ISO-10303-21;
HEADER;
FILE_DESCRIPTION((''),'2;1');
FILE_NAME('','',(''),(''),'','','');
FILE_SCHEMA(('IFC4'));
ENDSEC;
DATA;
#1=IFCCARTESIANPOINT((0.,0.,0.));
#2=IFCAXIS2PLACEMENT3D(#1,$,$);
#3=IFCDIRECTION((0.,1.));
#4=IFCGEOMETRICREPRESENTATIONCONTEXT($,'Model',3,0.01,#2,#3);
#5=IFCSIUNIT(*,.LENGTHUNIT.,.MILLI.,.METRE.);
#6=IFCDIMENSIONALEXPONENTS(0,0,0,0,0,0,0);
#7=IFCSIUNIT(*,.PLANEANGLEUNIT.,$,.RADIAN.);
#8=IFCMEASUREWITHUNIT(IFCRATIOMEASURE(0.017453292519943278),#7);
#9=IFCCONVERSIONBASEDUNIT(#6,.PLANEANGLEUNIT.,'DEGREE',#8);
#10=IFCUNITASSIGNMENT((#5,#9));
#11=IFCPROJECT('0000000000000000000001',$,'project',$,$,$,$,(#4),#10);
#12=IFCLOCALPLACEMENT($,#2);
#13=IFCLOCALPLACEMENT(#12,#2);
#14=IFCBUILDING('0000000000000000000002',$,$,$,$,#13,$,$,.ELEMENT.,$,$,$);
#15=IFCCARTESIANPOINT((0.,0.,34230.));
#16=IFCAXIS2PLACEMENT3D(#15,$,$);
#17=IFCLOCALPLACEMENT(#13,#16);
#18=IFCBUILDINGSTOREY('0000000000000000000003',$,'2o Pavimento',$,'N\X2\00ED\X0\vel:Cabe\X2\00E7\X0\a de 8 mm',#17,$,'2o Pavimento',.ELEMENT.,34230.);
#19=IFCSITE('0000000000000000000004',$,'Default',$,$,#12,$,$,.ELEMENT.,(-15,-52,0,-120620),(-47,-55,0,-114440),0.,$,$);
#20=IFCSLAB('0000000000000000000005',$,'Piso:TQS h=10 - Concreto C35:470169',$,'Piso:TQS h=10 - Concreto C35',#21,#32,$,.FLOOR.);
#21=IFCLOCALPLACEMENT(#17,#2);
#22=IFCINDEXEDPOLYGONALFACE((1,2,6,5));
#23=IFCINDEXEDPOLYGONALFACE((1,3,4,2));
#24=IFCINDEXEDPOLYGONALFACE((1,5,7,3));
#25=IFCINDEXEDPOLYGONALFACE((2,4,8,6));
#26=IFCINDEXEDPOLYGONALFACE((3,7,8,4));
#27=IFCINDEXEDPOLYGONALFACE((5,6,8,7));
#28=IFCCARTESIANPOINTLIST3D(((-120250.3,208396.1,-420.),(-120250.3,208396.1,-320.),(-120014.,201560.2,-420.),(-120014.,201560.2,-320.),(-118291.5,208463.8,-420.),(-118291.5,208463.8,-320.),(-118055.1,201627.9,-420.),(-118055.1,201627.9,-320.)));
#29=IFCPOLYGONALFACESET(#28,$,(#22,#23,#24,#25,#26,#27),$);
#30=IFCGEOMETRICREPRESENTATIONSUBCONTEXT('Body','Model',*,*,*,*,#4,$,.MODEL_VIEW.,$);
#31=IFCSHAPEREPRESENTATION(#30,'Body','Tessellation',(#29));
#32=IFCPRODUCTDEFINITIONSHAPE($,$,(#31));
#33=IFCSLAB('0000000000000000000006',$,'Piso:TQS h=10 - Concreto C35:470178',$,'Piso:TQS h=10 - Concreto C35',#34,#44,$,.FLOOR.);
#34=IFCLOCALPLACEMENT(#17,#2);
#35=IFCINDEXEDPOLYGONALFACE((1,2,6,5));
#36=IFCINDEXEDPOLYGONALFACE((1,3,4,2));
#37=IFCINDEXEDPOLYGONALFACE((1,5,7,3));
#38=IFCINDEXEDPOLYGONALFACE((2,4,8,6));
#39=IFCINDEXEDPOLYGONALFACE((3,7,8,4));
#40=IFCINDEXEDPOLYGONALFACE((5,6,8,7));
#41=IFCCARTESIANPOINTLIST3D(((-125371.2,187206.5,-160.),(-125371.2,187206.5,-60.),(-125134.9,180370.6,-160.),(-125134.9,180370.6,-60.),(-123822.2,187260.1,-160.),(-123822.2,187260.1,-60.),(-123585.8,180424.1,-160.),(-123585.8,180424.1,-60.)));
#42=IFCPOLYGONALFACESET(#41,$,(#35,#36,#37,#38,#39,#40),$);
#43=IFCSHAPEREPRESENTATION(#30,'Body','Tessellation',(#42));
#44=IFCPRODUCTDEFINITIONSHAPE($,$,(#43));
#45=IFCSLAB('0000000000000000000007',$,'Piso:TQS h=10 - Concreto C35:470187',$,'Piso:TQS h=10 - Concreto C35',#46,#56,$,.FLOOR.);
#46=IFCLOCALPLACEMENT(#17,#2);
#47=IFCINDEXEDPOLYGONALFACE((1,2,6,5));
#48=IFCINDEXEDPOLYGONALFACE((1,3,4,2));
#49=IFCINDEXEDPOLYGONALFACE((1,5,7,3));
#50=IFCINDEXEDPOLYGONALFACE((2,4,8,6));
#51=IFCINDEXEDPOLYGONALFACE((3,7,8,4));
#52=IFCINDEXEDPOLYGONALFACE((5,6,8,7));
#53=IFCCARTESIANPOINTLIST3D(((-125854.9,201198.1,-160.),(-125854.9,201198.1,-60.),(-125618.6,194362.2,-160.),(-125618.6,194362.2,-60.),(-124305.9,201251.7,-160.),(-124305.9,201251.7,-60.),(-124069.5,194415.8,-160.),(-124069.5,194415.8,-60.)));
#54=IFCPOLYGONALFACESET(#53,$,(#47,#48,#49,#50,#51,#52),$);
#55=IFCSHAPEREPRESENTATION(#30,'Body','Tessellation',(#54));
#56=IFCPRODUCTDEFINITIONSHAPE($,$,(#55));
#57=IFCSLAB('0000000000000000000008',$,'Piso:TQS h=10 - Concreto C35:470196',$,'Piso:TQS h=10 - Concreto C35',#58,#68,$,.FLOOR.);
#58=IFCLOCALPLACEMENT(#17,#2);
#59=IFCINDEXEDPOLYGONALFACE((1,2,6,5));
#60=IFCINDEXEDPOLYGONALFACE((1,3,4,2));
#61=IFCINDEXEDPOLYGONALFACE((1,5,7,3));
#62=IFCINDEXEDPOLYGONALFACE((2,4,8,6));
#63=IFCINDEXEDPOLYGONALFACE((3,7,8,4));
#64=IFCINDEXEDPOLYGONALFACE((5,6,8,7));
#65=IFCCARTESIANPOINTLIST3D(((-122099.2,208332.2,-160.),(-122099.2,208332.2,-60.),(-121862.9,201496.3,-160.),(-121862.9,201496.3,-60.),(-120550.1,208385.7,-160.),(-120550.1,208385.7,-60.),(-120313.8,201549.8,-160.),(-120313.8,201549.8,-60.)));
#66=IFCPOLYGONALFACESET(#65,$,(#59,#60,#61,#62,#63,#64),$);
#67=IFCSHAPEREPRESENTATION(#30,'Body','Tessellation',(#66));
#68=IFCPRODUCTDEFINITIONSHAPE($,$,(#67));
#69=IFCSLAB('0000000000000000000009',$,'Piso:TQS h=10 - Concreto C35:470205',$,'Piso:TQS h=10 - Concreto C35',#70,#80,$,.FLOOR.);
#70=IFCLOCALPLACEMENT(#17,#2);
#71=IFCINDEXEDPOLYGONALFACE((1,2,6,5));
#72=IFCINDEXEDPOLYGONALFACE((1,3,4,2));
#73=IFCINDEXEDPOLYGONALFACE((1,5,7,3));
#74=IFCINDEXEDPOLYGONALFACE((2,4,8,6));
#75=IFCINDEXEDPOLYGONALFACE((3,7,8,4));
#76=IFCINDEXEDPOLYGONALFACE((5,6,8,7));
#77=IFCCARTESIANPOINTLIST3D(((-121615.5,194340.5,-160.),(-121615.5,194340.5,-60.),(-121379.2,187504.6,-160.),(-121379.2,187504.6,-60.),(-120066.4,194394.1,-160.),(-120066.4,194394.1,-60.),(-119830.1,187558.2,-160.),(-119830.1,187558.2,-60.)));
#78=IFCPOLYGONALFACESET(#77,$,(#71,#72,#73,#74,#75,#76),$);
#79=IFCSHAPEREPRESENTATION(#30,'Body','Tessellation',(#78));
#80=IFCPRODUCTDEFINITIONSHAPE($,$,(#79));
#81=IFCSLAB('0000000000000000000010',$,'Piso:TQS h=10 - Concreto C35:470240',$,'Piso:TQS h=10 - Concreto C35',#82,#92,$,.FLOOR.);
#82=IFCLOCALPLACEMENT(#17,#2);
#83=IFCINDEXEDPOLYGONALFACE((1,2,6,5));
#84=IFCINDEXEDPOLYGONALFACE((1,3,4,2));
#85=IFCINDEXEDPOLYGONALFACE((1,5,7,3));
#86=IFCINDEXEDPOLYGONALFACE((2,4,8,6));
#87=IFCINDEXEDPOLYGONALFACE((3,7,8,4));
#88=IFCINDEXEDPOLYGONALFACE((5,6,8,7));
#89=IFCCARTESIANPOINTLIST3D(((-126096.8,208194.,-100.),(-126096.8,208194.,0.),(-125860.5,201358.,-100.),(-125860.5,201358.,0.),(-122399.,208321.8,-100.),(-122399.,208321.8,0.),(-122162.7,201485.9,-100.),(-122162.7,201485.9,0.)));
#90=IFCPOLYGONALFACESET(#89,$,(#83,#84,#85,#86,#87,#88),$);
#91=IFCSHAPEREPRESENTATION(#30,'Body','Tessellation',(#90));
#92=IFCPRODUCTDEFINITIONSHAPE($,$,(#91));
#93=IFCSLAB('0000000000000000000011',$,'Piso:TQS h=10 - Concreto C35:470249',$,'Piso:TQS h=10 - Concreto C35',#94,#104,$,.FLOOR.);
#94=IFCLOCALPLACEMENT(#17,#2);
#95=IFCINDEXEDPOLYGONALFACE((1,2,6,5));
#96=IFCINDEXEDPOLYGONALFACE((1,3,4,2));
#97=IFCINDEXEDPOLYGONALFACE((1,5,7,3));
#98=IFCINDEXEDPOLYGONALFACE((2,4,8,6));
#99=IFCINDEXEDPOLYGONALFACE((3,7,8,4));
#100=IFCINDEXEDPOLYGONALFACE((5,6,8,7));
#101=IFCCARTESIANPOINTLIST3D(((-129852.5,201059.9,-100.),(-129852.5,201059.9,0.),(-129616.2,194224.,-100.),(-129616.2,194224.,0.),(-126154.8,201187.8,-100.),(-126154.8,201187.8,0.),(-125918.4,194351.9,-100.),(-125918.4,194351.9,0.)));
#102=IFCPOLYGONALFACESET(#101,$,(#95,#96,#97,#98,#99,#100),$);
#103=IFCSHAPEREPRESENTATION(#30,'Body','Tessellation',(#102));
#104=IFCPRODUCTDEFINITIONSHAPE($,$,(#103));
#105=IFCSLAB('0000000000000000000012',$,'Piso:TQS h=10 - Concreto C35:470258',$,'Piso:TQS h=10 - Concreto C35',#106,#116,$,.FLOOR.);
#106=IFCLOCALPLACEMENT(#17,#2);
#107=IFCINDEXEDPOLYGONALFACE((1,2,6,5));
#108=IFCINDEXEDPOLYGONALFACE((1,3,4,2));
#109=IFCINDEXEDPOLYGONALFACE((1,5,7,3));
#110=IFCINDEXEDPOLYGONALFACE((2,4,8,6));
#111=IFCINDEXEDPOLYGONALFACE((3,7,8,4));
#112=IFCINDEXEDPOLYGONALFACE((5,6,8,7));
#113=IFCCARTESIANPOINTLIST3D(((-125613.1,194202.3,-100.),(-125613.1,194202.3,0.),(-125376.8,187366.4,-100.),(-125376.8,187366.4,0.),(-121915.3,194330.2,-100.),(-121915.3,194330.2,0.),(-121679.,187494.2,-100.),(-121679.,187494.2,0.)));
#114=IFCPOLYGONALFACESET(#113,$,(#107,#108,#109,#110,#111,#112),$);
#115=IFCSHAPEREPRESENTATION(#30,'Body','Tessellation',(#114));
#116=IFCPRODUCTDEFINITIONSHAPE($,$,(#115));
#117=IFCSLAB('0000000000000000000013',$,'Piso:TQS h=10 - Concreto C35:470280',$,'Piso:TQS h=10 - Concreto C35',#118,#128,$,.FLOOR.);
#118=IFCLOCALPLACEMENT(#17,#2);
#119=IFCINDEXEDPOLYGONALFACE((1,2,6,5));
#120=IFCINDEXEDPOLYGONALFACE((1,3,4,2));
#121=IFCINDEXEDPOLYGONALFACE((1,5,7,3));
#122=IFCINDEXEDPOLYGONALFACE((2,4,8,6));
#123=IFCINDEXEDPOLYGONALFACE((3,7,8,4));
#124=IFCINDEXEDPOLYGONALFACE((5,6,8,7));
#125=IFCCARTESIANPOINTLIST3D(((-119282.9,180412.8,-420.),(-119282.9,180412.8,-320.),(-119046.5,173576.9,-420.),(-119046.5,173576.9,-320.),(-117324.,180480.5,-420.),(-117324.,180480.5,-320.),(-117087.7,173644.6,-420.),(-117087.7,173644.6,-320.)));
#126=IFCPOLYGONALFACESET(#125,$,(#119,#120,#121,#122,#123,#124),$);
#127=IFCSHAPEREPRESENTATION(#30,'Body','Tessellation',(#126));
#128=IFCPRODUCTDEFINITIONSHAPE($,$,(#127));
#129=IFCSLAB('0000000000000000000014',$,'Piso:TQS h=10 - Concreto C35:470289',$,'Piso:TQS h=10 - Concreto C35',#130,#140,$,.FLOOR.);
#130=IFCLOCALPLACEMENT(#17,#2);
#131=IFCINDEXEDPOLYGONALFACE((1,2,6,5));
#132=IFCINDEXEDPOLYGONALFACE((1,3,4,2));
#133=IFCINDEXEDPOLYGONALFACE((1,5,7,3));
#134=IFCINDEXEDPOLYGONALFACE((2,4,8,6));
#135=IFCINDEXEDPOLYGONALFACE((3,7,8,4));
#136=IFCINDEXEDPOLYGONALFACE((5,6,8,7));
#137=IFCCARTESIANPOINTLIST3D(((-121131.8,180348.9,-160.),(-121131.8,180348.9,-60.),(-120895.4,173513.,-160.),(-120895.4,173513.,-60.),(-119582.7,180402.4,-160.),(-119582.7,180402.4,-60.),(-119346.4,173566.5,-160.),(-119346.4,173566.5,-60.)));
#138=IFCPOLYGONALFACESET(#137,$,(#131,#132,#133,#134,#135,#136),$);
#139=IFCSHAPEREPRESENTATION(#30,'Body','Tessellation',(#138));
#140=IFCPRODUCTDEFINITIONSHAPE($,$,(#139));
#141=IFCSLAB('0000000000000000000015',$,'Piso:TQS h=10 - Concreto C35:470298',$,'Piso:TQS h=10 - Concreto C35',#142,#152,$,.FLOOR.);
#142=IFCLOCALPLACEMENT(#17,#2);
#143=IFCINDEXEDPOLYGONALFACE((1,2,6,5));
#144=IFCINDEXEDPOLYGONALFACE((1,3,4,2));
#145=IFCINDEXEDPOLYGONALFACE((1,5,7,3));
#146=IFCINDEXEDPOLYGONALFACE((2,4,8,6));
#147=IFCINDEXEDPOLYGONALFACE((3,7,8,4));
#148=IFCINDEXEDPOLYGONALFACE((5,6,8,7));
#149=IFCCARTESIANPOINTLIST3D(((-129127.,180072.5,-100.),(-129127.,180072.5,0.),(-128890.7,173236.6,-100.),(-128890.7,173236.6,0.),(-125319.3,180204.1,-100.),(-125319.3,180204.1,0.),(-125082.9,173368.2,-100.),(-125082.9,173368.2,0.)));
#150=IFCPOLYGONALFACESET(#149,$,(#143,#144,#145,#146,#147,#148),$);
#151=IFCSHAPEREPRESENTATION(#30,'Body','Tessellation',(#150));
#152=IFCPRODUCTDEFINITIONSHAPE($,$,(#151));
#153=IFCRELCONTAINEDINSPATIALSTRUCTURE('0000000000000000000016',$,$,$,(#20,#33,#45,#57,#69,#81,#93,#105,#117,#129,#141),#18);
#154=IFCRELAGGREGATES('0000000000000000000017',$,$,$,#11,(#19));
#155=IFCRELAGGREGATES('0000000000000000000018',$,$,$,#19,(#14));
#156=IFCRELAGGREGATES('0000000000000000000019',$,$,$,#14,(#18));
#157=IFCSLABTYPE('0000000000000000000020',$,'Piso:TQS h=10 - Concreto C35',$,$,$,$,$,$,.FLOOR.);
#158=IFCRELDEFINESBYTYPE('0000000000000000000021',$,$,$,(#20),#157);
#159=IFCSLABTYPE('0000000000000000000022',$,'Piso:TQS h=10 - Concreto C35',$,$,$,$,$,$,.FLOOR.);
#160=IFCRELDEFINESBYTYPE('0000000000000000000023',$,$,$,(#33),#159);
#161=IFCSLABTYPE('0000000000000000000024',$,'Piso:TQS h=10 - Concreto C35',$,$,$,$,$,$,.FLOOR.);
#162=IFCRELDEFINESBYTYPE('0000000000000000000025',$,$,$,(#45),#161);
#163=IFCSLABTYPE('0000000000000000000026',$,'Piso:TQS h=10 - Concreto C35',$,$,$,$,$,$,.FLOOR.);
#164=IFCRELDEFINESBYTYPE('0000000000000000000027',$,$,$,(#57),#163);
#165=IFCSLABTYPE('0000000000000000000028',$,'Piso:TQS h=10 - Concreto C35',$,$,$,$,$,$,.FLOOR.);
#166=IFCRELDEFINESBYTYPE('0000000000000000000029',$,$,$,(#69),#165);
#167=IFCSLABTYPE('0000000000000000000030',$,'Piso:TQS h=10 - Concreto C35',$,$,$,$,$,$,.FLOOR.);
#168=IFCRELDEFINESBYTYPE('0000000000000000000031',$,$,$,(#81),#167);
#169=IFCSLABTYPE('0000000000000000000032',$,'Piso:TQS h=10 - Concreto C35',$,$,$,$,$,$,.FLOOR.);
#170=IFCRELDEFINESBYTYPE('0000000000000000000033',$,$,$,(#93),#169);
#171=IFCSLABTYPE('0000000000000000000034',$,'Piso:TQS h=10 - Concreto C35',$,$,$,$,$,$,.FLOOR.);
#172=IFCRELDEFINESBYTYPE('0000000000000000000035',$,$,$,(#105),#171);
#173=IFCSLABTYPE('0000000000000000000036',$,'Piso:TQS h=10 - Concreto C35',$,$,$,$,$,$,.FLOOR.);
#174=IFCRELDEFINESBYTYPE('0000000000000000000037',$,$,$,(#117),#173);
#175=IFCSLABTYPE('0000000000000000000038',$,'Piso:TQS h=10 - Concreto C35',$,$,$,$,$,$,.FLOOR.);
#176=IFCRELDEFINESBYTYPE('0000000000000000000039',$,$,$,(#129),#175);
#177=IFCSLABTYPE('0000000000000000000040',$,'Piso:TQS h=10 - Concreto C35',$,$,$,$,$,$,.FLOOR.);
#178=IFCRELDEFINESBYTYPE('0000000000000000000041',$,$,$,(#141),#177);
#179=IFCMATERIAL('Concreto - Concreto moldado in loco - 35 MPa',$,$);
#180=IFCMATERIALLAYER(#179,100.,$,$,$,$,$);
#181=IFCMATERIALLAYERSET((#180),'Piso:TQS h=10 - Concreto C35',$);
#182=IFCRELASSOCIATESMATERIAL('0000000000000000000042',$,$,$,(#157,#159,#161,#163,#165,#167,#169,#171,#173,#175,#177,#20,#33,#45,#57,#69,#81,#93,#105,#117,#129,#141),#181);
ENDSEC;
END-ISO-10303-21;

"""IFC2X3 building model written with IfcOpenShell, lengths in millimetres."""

from ifc_helpers import new_model, entity, si_unit, converted_unit, direction, frame, frame_2d, origin, origin_2d_with_axis, place, context, subcontext, project, spatial, rectangle, extrude, material, layer, layer_set, layer_usage, type_object, element, save


model = new_model("IFC2X3")

# Units and contexts
model_context = context("Model", 3, precision=0.01, world=origin(), true_north=direction((0.0, 1.0)))
body_context = subcontext(model_context, "Body", "Model", "MODEL_VIEW")
ifc_project = project(units=[si_unit("LENGTHUNIT", "METRE", prefix="MILLI"), converted_unit("PLANEANGLEUNIT", "DEGREE", entity("IfcRatioMeasure", 0.017453292519943278), si_unit("PLANEANGLEUNIT", "RADIAN"), dimensions=[0, 0, 0, 0, 0, 0, 0])], contexts=[model_context])

# Site, building, storey
site_placement = place(None, origin())
site = spatial("IfcSite", under=ifc_project, at=site_placement, Name="Default", CompositionType="ELEMENT", RefLatitude=(-15, -52, 0, -120620), RefLongitude=(-47, -55, 0, -114440), RefElevation=0.0)
building_placement = place(site_placement, origin())
building = spatial("IfcBuilding", under=site, at=building_placement, CompositionType="ELEMENT")
storey_placement = place(building_placement, frame((0.0, 0.0, 34230.0)))
storey = spatial("IfcBuildingStorey", under=building, at=storey_placement, Name="2o Pavimento", ObjectType="Nível:Cabeça de 8 mm", LongName="2o Pavimento", CompositionType="ELEMENT", Elevation=34230.0)

# Shared definitions
ifc_material = material(Name="Concreto - Concreto moldado in loco - 35 MPa")

# Slabs
ifc_layer = layer(ifc_material, 100.0)
ifc_layer_set = layer_set([ifc_layer], Name="Piso:TQS h=10 - Concreto C35")
ifc_layer_usage_1 = layer_usage(ifc_layer_set, "AXIS3", "POSITIVE", 0.0)
slab_type_1 = type_object("IfcSlabType", Name="Piso:TQS h=10 - Concreto C35", PredefinedType="FLOOR", material=ifc_layer_set)
slab_1_placement = place(storey_placement, origin())
element("IfcSlab", 1, at=slab_1_placement, inside=storey, type_object=slab_type_1, material=ifc_layer_usage_1, Name="Piso:TQS h=10 - Concreto C35:470169", ObjectType="Piso:TQS h=10 - Concreto C35", PredefinedType="FLOOR", context=body_context, shape_type="SweptSolid", body=[
    extrude(rectangle(XDim=6840.0, YDim=1960.0, at=frame_2d((0.0, 0.0), x_axis=(1.0, 0.0))), frame((-119152.7, 205012.0, -320.0), z_axis=(0.0, 0.0, -1.0), x_axis=(0.034551, -0.999403, 0.0)), (0.0, 0.0, 1.0), 100.0),
])
ifc_layer_usage_2 = layer_usage(ifc_layer_set, "AXIS3", "POSITIVE", 0.0)
slab_type_2 = type_object("IfcSlabType", Name="Piso:TQS h=10 - Concreto C35", PredefinedType="FLOOR", material=ifc_layer_set)
slab_2_placement = place(storey_placement, origin())
element("IfcSlab", 2, at=slab_2_placement, inside=storey, type_object=slab_type_2, material=ifc_layer_usage_2, Name="Piso:TQS h=10 - Concreto C35:470178", ObjectType="Piso:TQS h=10 - Concreto C35", PredefinedType="FLOOR", context=body_context, shape_type="SweptSolid", body=[
    extrude(rectangle(XDim=6840.0, YDim=1550.0, at=frame_2d((0.0, 0.0), x_axis=(1.0, 0.0))), frame((-124478.5, 183815.3, -60.0), z_axis=(0.0, 0.0, -1.0), x_axis=(0.034551, -0.999403, 0.0)), (0.0, 0.0, 1.0), 100.0),
])
ifc_layer_usage_3 = layer_usage(ifc_layer_set, "AXIS3", "POSITIVE", 0.0)
slab_type_3 = type_object("IfcSlabType", Name="Piso:TQS h=10 - Concreto C35", PredefinedType="FLOOR", material=ifc_layer_set)
slab_3_placement = place(storey_placement, origin())
element("IfcSlab", 3, at=slab_3_placement, inside=storey, type_object=slab_type_3, material=ifc_layer_usage_3, Name="Piso:TQS h=10 - Concreto C35:470187", ObjectType="Piso:TQS h=10 - Concreto C35", PredefinedType="FLOOR", context=body_context, shape_type="SweptSolid", body=[
    extrude(rectangle(XDim=6840.0, YDim=1550.0, at=frame_2d((0.0, 0.0), x_axis=(1.0, 0.0))), frame((-124962.2, 197807.0, -60.0), z_axis=(0.0, 0.0, -1.0), x_axis=(0.034551, -0.999403, 0.0)), (0.0, 0.0, 1.0), 100.0),
])
ifc_layer_usage_4 = layer_usage(ifc_layer_set, "AXIS3", "POSITIVE", 0.0)
slab_type_4 = type_object("IfcSlabType", Name="Piso:TQS h=10 - Concreto C35", PredefinedType="FLOOR", material=ifc_layer_set)
slab_4_placement = place(storey_placement, origin())
element("IfcSlab", 4, at=slab_4_placement, inside=storey, type_object=slab_type_4, material=ifc_layer_usage_4, Name="Piso:TQS h=10 - Concreto C35:470196", ObjectType="Piso:TQS h=10 - Concreto C35", PredefinedType="FLOOR", context=body_context, shape_type="SweptSolid", body=[
    extrude(rectangle(XDim=6840.0, YDim=1550.0, at=frame_2d((0.0, 0.0), x_axis=(1.0, 0.0))), frame((-121206.5, 204941.0, -60.0), z_axis=(0.0, 0.0, -1.0), x_axis=(0.034551, -0.999403, 0.0)), (0.0, 0.0, 1.0), 100.0),
])
ifc_layer_usage_5 = layer_usage(ifc_layer_set, "AXIS3", "POSITIVE", 0.0)
slab_type_5 = type_object("IfcSlabType", Name="Piso:TQS h=10 - Concreto C35", PredefinedType="FLOOR", material=ifc_layer_set)
slab_5_placement = place(storey_placement, origin())
element("IfcSlab", 5, at=slab_5_placement, inside=storey, type_object=slab_type_5, material=ifc_layer_usage_5, Name="Piso:TQS h=10 - Concreto C35:470205", ObjectType="Piso:TQS h=10 - Concreto C35", PredefinedType="FLOOR", context=body_context, shape_type="SweptSolid", body=[
    extrude(rectangle(XDim=6840.0, YDim=1550.0, at=frame_2d((0.0, 0.0), x_axis=(1.0, 0.0))), frame((-120722.8, 190949.3, -60.0), z_axis=(0.0, 0.0, -1.0), x_axis=(0.034551, -0.999403, 0.0)), (0.0, 0.0, 1.0), 100.0),
])
ifc_layer_usage_6 = layer_usage(ifc_layer_set, "AXIS3", "POSITIVE", 0.0)
slab_type_6 = type_object("IfcSlabType", Name="Piso:TQS h=10 - Concreto C35", PredefinedType="FLOOR", material=ifc_layer_set)
slab_6_placement = place(storey_placement, origin())
element("IfcSlab", 6, at=slab_6_placement, inside=storey, type_object=slab_type_6, material=ifc_layer_usage_6, Name="Piso:TQS h=10 - Concreto C35:470240", ObjectType="Piso:TQS h=10 - Concreto C35", PredefinedType="FLOOR", context=body_context, shape_type="SweptSolid", body=[
    extrude(rectangle(XDim=6840.0, YDim=3700.0, at=frame_2d((0.0, 0.0), x_axis=(1.0, 0.0))), frame((-124129.7, 204839.9, 0.0), z_axis=(0.0, 0.0, -1.0), x_axis=(0.034551, -0.999403, 0.0)), (0.0, 0.0, 1.0), 100.0),
])
ifc_layer_usage_7 = layer_usage(ifc_layer_set, "AXIS3", "POSITIVE", 0.0)
slab_type_7 = type_object("IfcSlabType", Name="Piso:TQS h=10 - Concreto C35", PredefinedType="FLOOR", material=ifc_layer_set)
slab_7_placement = place(storey_placement, origin())
element("IfcSlab", 7, at=slab_7_placement, inside=storey, type_object=slab_type_7, material=ifc_layer_usage_7, Name="Piso:TQS h=10 - Concreto C35:470249", ObjectType="Piso:TQS h=10 - Concreto C35", PredefinedType="FLOOR", context=body_context, shape_type="SweptSolid", body=[
    extrude(rectangle(XDim=6840.0, YDim=3700.0, at=frame_2d((0.0, 0.0), x_axis=(1.0, 0.0))), frame((-127885.5, 197705.9, 0.0), z_axis=(0.0, 0.0, -1.0), x_axis=(0.034551, -0.999403, 0.0)), (0.0, 0.0, 1.0), 100.0),
])
ifc_layer_usage_8 = layer_usage(ifc_layer_set, "AXIS3", "POSITIVE", 0.0)
slab_type_8 = type_object("IfcSlabType", Name="Piso:TQS h=10 - Concreto C35", PredefinedType="FLOOR", material=ifc_layer_set)
slab_8_placement = place(storey_placement, origin())
element("IfcSlab", 8, at=slab_8_placement, inside=storey, type_object=slab_type_8, material=ifc_layer_usage_8, Name="Piso:TQS h=10 - Concreto C35:470258", ObjectType="Piso:TQS h=10 - Concreto C35", PredefinedType="FLOOR", context=body_context, shape_type="SweptSolid", body=[
    extrude(rectangle(XDim=6840.0, YDim=3700.0, at=frame_2d((0.0, 0.0), x_axis=(1.0, 0.0))), frame((-123646.0, 190848.3, 0.0), z_axis=(0.0, 0.0, -1.0), x_axis=(0.034551, -0.999403, 0.0)), (0.0, 0.0, 1.0), 100.0),
])
ifc_layer_usage_9 = layer_usage(ifc_layer_set, "AXIS3", "POSITIVE", 0.0)
slab_type_9 = type_object("IfcSlabType", Name="Piso:TQS h=10 - Concreto C35", PredefinedType="FLOOR", material=ifc_layer_set)
slab_9_placement = place(storey_placement, origin())
element("IfcSlab", 9, at=slab_9_placement, inside=storey, type_object=slab_type_9, material=ifc_layer_usage_9, Name="Piso:TQS h=10 - Concreto C35:470280", ObjectType="Piso:TQS h=10 - Concreto C35", PredefinedType="FLOOR", context=body_context, shape_type="SweptSolid", body=[
    extrude(rectangle(XDim=6840.0, YDim=1960.0, at=frame_2d((0.0, 0.0), x_axis=(1.0, 0.0))), frame((-118185.3, 177028.7, -320.0), z_axis=(0.0, 0.0, -1.0), x_axis=(0.034551, -0.999403, 0.0)), (0.0, 0.0, 1.0), 100.0),
])
ifc_layer_usage_10 = layer_usage(ifc_layer_set, "AXIS3", "POSITIVE", 0.0)
slab_type_10 = type_object("IfcSlabType", Name="Piso:TQS h=10 - Concreto C35", PredefinedType="FLOOR", material=ifc_layer_set)
slab_10_placement = place(storey_placement, origin())
element("IfcSlab", 10, at=slab_10_placement, inside=storey, type_object=slab_type_10, material=ifc_layer_usage_10, Name="Piso:TQS h=10 - Concreto C35:470289", ObjectType="Piso:TQS h=10 - Concreto C35", PredefinedType="FLOOR", context=body_context, shape_type="SweptSolid", body=[
    extrude(rectangle(XDim=1550.0, YDim=6840.0, at=frame_2d((0.0, 0.0), x_axis=(1.0, 0.0))), frame((-120239.1, 176957.7, -60.0), z_axis=(0.0, 0.0, -1.0), x_axis=(0.999403, 0.034551, 0.0)), (0.0, 0.0, 1.0), 100.0),
])
ifc_layer_usage_11 = layer_usage(ifc_layer_set, "AXIS3", "POSITIVE", 0.0)
slab_type_11 = type_object("IfcSlabType", Name="Piso:TQS h=10 - Concreto C35", PredefinedType="FLOOR", material=ifc_layer_set)
slab_11_placement = place(storey_placement, origin())
element("IfcSlab", 11, at=slab_11_placement, inside=storey, type_object=slab_type_11, material=ifc_layer_usage_11, Name="Piso:TQS h=10 - Concreto C35:470298", ObjectType="Piso:TQS h=10 - Concreto C35", PredefinedType="FLOOR", context=body_context, shape_type="SweptSolid", body=[
    extrude(rectangle(XDim=3810.0, YDim=6840.0, at=origin_2d_with_axis()), frame((-127105.0, 176720.3, 0.0), z_axis=(0.0, 0.0, -1.0), x_axis=(0.999403, 0.034551, 0.0)), (0.0, 0.0, 1.0), 100.0),
])

save(model, "model.ifc")
